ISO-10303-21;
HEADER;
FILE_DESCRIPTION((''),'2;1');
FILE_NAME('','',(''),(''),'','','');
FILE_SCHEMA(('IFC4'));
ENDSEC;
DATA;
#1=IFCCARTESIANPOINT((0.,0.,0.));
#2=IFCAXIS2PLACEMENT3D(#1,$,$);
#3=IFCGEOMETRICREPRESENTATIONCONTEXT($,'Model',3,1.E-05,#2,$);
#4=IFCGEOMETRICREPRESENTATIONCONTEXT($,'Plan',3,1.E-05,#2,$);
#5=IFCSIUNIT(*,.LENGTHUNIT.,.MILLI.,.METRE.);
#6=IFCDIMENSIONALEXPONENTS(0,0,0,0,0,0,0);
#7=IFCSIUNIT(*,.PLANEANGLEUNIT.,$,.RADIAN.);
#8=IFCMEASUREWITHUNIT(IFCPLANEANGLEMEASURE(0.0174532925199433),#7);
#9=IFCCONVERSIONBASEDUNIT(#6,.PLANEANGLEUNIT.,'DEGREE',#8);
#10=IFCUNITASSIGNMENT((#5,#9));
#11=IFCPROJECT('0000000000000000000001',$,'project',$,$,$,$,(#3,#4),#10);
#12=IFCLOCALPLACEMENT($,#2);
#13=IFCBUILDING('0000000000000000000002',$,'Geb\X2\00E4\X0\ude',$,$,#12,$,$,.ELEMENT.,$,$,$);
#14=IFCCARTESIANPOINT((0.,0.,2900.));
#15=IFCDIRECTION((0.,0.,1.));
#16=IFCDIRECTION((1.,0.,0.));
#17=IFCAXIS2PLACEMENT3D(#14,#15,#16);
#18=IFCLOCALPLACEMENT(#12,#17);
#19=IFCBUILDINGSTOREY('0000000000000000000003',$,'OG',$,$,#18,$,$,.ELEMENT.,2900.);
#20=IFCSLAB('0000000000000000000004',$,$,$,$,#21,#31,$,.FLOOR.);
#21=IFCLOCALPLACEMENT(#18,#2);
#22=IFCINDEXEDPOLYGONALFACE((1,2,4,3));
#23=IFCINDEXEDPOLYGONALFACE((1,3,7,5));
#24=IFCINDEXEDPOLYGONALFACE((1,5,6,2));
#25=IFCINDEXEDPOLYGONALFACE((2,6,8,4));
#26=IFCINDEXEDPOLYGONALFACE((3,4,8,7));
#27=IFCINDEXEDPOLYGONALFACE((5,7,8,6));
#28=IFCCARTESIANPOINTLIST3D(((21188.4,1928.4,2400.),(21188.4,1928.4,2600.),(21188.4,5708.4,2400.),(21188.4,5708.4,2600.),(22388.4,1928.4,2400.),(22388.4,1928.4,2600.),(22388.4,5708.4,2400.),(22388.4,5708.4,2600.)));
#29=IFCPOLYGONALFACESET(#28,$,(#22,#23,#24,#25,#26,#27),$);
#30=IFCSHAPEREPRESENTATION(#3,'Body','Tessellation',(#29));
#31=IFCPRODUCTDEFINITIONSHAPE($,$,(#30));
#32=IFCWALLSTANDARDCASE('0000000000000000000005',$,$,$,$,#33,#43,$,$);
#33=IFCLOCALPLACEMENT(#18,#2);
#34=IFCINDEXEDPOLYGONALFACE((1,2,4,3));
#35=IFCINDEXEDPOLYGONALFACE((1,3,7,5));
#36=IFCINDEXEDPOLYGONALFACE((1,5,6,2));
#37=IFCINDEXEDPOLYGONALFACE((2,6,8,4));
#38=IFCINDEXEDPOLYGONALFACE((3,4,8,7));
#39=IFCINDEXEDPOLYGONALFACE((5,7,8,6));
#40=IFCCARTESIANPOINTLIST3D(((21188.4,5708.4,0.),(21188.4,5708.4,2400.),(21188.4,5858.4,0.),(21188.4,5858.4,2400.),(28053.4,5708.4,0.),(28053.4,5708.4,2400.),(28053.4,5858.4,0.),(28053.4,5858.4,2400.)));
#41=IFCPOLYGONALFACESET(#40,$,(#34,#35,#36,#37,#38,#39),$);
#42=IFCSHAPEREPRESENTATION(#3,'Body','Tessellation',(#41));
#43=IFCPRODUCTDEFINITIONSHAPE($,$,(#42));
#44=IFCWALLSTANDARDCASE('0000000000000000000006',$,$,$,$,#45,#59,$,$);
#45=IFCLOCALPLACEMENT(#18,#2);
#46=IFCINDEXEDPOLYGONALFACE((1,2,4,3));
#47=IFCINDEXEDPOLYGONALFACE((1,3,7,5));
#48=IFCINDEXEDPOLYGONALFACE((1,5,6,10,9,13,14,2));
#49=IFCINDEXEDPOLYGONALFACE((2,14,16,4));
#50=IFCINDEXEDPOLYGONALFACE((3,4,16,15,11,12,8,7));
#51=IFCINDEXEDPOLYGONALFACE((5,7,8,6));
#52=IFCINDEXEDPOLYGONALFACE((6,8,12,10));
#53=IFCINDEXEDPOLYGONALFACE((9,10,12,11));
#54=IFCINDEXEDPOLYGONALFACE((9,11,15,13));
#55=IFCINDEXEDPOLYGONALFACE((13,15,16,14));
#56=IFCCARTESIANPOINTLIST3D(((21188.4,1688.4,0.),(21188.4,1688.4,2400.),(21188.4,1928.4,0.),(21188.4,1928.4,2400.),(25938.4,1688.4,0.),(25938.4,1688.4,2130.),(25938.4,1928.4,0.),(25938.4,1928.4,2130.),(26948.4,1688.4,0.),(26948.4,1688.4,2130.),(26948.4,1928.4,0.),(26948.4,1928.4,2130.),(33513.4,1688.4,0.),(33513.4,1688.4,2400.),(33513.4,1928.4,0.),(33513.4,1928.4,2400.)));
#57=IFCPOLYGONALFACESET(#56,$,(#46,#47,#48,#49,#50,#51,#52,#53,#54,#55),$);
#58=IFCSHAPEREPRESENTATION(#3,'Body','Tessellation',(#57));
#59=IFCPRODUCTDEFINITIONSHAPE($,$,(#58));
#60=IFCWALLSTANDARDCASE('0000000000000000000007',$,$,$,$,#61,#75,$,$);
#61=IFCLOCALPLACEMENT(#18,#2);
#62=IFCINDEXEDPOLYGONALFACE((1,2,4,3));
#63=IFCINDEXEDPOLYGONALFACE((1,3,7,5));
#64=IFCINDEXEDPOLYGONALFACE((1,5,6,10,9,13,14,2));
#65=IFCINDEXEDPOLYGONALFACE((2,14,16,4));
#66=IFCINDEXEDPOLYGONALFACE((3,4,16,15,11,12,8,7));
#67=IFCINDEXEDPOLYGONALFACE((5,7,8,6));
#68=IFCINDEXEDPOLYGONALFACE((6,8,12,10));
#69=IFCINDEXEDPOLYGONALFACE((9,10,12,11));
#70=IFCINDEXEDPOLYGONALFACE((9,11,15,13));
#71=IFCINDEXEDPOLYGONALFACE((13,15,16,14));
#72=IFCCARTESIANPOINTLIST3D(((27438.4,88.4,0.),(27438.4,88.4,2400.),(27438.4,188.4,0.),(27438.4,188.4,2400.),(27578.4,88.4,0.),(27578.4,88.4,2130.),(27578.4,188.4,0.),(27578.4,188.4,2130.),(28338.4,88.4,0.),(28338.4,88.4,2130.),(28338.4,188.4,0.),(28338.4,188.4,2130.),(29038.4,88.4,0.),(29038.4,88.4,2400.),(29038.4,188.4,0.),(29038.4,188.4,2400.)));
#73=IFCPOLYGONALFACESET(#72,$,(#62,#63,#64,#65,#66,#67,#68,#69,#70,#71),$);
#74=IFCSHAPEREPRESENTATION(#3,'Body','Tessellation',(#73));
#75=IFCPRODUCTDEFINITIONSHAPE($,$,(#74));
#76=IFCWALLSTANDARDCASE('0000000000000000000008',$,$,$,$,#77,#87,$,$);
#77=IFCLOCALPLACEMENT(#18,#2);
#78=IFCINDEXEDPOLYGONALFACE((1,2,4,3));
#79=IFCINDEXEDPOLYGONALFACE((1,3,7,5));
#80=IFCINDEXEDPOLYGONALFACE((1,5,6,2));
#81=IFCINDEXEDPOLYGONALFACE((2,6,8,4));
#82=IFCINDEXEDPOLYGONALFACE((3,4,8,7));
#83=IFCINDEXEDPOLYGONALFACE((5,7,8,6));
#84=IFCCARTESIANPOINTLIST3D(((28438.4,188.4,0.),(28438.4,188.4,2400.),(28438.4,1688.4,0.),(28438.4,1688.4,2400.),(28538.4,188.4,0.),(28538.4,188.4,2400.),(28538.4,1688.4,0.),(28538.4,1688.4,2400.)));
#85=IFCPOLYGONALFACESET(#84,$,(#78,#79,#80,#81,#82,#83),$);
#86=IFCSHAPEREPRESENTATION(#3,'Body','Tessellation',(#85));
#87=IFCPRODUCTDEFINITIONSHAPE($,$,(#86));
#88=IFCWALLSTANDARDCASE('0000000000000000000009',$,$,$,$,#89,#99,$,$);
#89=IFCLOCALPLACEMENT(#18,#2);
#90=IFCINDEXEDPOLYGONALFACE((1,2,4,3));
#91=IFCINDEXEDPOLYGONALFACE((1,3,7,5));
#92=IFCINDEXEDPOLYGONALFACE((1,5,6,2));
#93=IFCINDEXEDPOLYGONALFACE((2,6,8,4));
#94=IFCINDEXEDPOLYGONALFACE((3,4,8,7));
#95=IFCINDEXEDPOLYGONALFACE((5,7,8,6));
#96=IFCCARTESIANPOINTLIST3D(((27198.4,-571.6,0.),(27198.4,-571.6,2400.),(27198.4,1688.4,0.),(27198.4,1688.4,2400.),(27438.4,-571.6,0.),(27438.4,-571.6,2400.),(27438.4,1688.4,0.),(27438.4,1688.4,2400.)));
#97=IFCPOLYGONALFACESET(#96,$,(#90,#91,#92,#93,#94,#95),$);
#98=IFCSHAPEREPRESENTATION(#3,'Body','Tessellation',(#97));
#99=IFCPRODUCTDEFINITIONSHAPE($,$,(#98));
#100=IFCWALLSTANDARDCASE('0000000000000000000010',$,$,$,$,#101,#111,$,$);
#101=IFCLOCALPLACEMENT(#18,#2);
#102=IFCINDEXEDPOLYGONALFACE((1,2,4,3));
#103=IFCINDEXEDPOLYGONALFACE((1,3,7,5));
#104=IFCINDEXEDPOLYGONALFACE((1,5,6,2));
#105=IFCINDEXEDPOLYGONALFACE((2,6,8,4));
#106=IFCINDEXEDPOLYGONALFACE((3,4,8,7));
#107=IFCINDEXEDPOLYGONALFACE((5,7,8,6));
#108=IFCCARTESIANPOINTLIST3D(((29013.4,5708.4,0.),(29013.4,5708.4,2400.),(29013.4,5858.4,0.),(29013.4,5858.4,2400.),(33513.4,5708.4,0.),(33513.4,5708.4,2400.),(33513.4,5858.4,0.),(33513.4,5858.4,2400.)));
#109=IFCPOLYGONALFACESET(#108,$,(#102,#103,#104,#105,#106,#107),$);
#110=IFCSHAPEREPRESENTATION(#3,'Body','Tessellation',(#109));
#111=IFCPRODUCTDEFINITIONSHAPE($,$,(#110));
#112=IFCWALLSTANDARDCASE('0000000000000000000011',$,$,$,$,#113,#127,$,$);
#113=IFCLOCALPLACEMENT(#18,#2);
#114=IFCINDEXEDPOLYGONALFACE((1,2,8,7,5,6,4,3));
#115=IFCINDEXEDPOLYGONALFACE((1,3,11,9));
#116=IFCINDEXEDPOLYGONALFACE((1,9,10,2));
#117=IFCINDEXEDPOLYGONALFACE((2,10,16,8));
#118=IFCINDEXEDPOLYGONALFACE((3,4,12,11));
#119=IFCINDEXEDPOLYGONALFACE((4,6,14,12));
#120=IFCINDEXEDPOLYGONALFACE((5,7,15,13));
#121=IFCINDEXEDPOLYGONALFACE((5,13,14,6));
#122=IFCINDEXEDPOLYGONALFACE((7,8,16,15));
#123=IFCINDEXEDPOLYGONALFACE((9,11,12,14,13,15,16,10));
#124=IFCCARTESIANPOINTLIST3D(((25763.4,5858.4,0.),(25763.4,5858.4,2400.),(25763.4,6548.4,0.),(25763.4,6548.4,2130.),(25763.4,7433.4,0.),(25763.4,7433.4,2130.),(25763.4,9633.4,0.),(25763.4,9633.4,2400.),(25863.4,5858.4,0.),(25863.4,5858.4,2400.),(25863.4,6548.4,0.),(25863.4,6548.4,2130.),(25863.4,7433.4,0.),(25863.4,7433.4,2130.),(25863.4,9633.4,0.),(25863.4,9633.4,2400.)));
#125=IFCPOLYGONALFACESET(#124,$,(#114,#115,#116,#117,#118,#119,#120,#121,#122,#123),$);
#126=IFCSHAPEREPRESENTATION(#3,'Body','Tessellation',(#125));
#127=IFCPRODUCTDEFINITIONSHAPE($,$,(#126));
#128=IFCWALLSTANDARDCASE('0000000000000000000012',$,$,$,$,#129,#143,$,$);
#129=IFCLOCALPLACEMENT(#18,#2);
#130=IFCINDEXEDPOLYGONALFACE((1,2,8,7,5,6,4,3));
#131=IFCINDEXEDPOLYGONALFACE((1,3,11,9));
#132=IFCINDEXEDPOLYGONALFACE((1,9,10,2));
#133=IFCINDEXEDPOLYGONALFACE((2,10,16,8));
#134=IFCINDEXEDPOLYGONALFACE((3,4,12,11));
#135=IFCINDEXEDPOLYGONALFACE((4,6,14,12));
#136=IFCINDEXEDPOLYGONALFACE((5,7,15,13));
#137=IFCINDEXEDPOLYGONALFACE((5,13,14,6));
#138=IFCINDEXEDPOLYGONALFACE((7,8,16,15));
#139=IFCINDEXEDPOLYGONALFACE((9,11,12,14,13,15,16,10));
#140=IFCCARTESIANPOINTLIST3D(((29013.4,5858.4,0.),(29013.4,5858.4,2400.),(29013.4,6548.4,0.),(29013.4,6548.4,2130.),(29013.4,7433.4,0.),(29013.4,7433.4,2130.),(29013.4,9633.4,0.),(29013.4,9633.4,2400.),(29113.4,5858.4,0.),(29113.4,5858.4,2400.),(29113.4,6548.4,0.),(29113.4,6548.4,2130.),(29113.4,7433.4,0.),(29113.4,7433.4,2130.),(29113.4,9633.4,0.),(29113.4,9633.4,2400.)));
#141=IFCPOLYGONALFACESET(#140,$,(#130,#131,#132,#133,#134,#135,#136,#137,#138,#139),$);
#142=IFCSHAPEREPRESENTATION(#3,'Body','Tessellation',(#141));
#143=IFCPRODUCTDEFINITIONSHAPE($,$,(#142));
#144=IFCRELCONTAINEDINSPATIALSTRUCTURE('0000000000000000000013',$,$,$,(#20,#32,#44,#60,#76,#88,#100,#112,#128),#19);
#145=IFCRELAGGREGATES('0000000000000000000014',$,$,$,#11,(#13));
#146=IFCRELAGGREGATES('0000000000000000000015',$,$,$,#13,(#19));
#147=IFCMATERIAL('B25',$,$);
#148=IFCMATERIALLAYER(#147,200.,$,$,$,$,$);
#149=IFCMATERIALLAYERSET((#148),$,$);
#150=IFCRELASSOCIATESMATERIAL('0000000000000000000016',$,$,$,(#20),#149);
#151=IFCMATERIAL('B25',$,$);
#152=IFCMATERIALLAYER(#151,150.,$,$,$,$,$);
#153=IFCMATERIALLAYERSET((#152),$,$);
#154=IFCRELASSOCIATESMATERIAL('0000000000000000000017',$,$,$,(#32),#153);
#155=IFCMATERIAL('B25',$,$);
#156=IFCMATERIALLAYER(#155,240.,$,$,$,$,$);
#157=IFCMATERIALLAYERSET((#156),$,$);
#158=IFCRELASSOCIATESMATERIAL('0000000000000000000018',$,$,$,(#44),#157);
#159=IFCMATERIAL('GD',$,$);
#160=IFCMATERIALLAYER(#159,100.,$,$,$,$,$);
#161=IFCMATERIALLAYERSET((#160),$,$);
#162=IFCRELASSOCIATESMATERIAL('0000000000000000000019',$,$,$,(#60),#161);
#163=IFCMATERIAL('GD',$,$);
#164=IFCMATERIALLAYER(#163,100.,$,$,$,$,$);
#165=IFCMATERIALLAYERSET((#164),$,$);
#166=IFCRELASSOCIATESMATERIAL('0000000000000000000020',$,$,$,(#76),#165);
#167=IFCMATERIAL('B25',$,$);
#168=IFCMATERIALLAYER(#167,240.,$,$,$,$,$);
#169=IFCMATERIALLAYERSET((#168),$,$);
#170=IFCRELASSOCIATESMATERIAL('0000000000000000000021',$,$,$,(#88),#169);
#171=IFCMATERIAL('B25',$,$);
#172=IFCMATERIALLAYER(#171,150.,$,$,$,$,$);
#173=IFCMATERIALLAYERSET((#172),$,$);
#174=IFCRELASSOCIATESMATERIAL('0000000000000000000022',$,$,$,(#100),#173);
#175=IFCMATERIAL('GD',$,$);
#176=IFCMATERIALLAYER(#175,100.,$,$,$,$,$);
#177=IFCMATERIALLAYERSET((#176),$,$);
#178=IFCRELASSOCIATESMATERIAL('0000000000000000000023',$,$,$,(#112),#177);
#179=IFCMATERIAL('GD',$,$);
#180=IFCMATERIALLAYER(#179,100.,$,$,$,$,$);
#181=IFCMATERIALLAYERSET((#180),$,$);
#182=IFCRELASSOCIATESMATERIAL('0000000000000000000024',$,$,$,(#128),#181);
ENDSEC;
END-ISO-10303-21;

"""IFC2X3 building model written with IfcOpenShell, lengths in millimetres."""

from ifc_helpers import new_model, entity, si_unit, converted_unit, frame, frame_2d, origin, origin_with_axes, place, context, project, spatial, rectangle, extrude, material, layer, layer_set, layer_usage, element, save


model = new_model("IFC2X3")

# Units and contexts
model_context = context("Model", 3, precision=1e-05, world=origin())
plan_context = context("Plan", 3, precision=1e-05, world=origin())
ifc_project = project(units=[si_unit("LENGTHUNIT", "METRE", prefix="MILLI"), converted_unit("PLANEANGLEUNIT", "DEGREE", entity("IfcPlaneAngleMeasure", 0.0174532925199433), si_unit("PLANEANGLEUNIT", "RADIAN"), dimensions=[0, 0, 0, 0, 0, 0, 0])], contexts=[model_context, plan_context])

# Building, storey
building_placement = place(None, origin())
building = spatial("IfcBuilding", under=ifc_project, at=building_placement, Name="Gebäude", CompositionType="ELEMENT")
storey_placement = place(building_placement, frame((0.0, 0.0, 2900.0), z_axis=(0.0, 0.0, 1.0), x_axis=(1.0, 0.0, 0.0)))
storey = spatial("IfcBuildingStorey", under=building, at=storey_placement, Name="OG", CompositionType="ELEMENT", Elevation=2900.0)

# Slab
ifc_material_1 = material(Name="B25")
ifc_layer_1 = layer(ifc_material_1, 200.0)
ifc_layer_set_1 = layer_set([ifc_layer_1])
ifc_layer_usage_1 = layer_usage(ifc_layer_set_1, "AXIS3", "POSITIVE", 0.0)
slab_placement = place(storey_placement, frame((21188.4, 5708.4, 2400.0), z_axis=(0.0, 0.0, 1.0), x_axis=(1.0, 0.0, 0.0)))
element("IfcSlab", 1, at=slab_placement, inside=storey, material=ifc_layer_usage_1, PredefinedType="FLOOR", context=model_context, shape_type="SweptSolid", body=[
    extrude(rectangle(XDim=3780.0, YDim=1200.0, at=frame_2d((600.0, -1890.0), x_axis=(0.0, -1.0))), origin_with_axes(), (0.0, 0.0, 1.0), 200.0),
])

# Wall
ifc_material_2 = material(Name="B25")
ifc_layer_2 = layer(ifc_material_2, 150.0)
ifc_layer_set_2 = layer_set([ifc_layer_2])
ifc_layer_usage_2 = layer_usage(ifc_layer_set_2, "AXIS2", "POSITIVE", 0.0)
wall_1_placement = place(storey_placement, frame((21188.4, 5708.4, 0.0), z_axis=(0.0, 0.0, 1.0), x_axis=(1.0, 0.0, 0.0)))
element("IfcWallStandardCase", 2, at=wall_1_placement, inside=storey, material=ifc_layer_usage_2, context=model_context, shape_type="SweptSolid", body=[
    extrude(rectangle(XDim=6865.0, YDim=150.0, at=frame_2d((3432.5, 75.0), x_axis=(1.0, 0.0))), origin_with_axes(), (0.0, 0.0, 1.0), 2400.0),
])

# Walls, openings
ifc_material_3 = material(Name="B25")
ifc_layer_3 = layer(ifc_material_3, 240.0)
ifc_layer_set_3 = layer_set([ifc_layer_3])
ifc_layer_usage_3 = layer_usage(ifc_layer_set_3, "AXIS2", "POSITIVE", 0.0)
wall_2_placement = place(storey_placement, frame((33513.4, 1928.4, 0.0), z_axis=(0.0, 0.0, 1.0), x_axis=(-1.0, 0.0, 0.0)))
wall_2 = element("IfcWallStandardCase", 3, at=wall_2_placement, inside=storey, material=ifc_layer_usage_3, context=model_context, shape_type="SweptSolid", body=[
    extrude(rectangle(XDim=12325.0, YDim=240.0, at=frame_2d((6162.5, 120.0), x_axis=(1.0, 0.0))), origin_with_axes(), (0.0, 0.0, 1.0), 2400.0),
])
opening_1_placement = place(wall_2_placement, frame((6565.0, 0.0, 0.0), z_axis=(0.0, 1.0, 0.0), x_axis=(0.0, 0.0, 1.0)))
element("IfcOpeningElement", 4, at=opening_1_placement, cuts=wall_2, ObjectType="Opening", context=model_context, shape_type="SweptSolid", body=[
    extrude(rectangle(XDim=2130.0, YDim=1010.0, at=frame_2d((1065.0, 505.0), x_axis=(1.0, 0.0))), origin_with_axes(), (0.0, 0.0, 1.0), 240.0),
])
ifc_material_4 = material(Name="GD")
ifc_layer_4 = layer(ifc_material_4, 100.0)
ifc_layer_set_4 = layer_set([ifc_layer_4])
ifc_layer_usage_4 = layer_usage(ifc_layer_set_4, "AXIS2", "POSITIVE", 0.0)
wall_3_placement = place(storey_placement, frame((29038.4, 188.4, 0.0), z_axis=(0.0, 0.0, 1.0), x_axis=(-1.0, 0.0, 0.0)))
wall_3 = element("IfcWallStandardCase", 5, at=wall_3_placement, inside=storey, material=ifc_layer_usage_4, context=model_context, shape_type="SweptSolid", body=[
    extrude(rectangle(XDim=1600.0, YDim=100.0, at=frame_2d((800.0, 50.0), x_axis=(1.0, 0.0))), origin_with_axes(), (0.0, 0.0, 1.0), 2400.0),
])
opening_2_placement = place(wall_3_placement, frame((700.0, 0.0, 0.0), z_axis=(0.0, 1.0, 0.0), x_axis=(0.0, 0.0, 1.0)))
element("IfcOpeningElement", 6, at=opening_2_placement, cuts=wall_3, ObjectType="Opening", context=model_context, shape_type="SweptSolid", body=[
    extrude(rectangle(XDim=2130.0, YDim=760.0, at=frame_2d((1065.0, 380.0), x_axis=(1.0, 0.0))), origin_with_axes(), (0.0, 0.0, 1.0), 100.0),
])

# Walls
ifc_material_5 = material(Name="GD")
ifc_layer_5 = layer(ifc_material_5, 100.0)
ifc_layer_set_5 = layer_set([ifc_layer_5])
ifc_layer_usage_5 = layer_usage(ifc_layer_set_5, "AXIS2", "POSITIVE", 0.0)
wall_4_placement = place(storey_placement, frame((28438.4, 1688.4, 0.0), z_axis=(0.0, 0.0, 1.0), x_axis=(0.0, -1.0, 0.0)))
element("IfcWallStandardCase", 7, at=wall_4_placement, inside=storey, material=ifc_layer_usage_5, context=model_context, shape_type="SweptSolid", body=[
    extrude(rectangle(XDim=1500.0, YDim=100.0, at=frame_2d((750.0, 50.0), x_axis=(1.0, 0.0))), origin_with_axes(), (0.0, 0.0, 1.0), 2400.0),
])
ifc_material_6 = material(Name="B25")
ifc_layer_6 = layer(ifc_material_6, 240.0)
ifc_layer_set_6 = layer_set([ifc_layer_6])
ifc_layer_usage_6 = layer_usage(ifc_layer_set_6, "AXIS2", "POSITIVE", 0.0)
wall_5_placement = place(storey_placement, frame((27198.4, 1688.4, 0.0), z_axis=(0.0, 0.0, 1.0), x_axis=(0.0, -1.0, 0.0)))
element("IfcWallStandardCase", 8, at=wall_5_placement, inside=storey, material=ifc_layer_usage_6, context=model_context, shape_type="SweptSolid", body=[
    extrude(rectangle(XDim=2260.0, YDim=240.0, at=frame_2d((1130.0, 120.0), x_axis=(1.0, 0.0))), origin_with_axes(), (0.0, 0.0, 1.0), 2400.0),
])
ifc_material_7 = material(Name="B25")
ifc_layer_7 = layer(ifc_material_7, 150.0)
ifc_layer_set_7 = layer_set([ifc_layer_7])
ifc_layer_usage_7 = layer_usage(ifc_layer_set_7, "AXIS2", "POSITIVE", 0.0)
wall_6_placement = place(storey_placement, frame((29013.4, 5708.4, 0.0), z_axis=(0.0, 0.0, 1.0), x_axis=(1.0, 0.0, 0.0)))
element("IfcWallStandardCase", 9, at=wall_6_placement, inside=storey, material=ifc_layer_usage_7, context=model_context, shape_type="SweptSolid", body=[
    extrude(rectangle(XDim=4500.0, YDim=150.0, at=frame_2d((2250.0, 75.0), x_axis=(1.0, 0.0))), origin_with_axes(), (0.0, 0.0, 1.0), 2400.0),
])

# Walls, openings
ifc_material_8 = material(Name="GD")
ifc_layer_8 = layer(ifc_material_8, 100.0)
ifc_layer_set_8 = layer_set([ifc_layer_8])
ifc_layer_usage_8 = layer_usage(ifc_layer_set_8, "AXIS2", "POSITIVE", 0.0)
wall_7_placement = place(storey_placement, frame((25763.4, 9633.4, 0.0), z_axis=(0.0, 0.0, 1.0), x_axis=(0.0, -1.0, 0.0)))
wall_7 = element("IfcWallStandardCase", 10, at=wall_7_placement, inside=storey, material=ifc_layer_usage_8, context=model_context, shape_type="SweptSolid", body=[
    extrude(rectangle(XDim=3775.0, YDim=100.0, at=frame_2d((1887.5, 50.0), x_axis=(1.0, 0.0))), origin_with_axes(), (0.0, 0.0, 1.0), 2400.0),
])
opening_3_placement = place(wall_7_placement, frame((2200.0, 0.0, 0.0), z_axis=(0.0, 1.0, 0.0), x_axis=(0.0, 0.0, 1.0)))
element("IfcOpeningElement", 11, at=opening_3_placement, cuts=wall_7, ObjectType="Opening", context=model_context, shape_type="SweptSolid", body=[
    extrude(rectangle(XDim=2130.0, YDim=885.0, at=frame_2d((1065.0, 442.5), x_axis=(1.0, 0.0))), origin_with_axes(), (0.0, 0.0, 1.0), 100.0),
])
ifc_material_9 = material(Name="GD")
ifc_layer_9 = layer(ifc_material_9, 100.0)
ifc_layer_set_9 = layer_set([ifc_layer_9])
ifc_layer_usage_9 = layer_usage(ifc_layer_set_9, "AXIS2", "POSITIVE", 0.0)
wall_8_placement = place(storey_placement, frame((29113.4, 5858.4, 0.0), z_axis=(0.0, 0.0, 1.0), x_axis=(0.0, 1.0, 0.0)))
wall_8 = element("IfcWallStandardCase", 12, at=wall_8_placement, inside=storey, material=ifc_layer_usage_9, context=model_context, shape_type="SweptSolid", body=[
    extrude(rectangle(XDim=3775.0, YDim=100.0, at=frame_2d((1887.5, 50.0), x_axis=(1.0, 0.0))), origin_with_axes(), (0.0, 0.0, 1.0), 2400.0),
])
opening_4_placement = place(wall_8_placement, frame((690.0, 0.0, 0.0), z_axis=(0.0, 1.0, 0.0), x_axis=(0.0, 0.0, 1.0)))
element("IfcOpeningElement", 13, at=opening_4_placement, cuts=wall_8, ObjectType="Opening", context=model_context, shape_type="SweptSolid", body=[
    extrude(rectangle(XDim=2130.0, YDim=885.0, at=frame_2d((1065.0, 442.5), x_axis=(1.0, 0.0))), origin_with_axes(), (0.0, 0.0, 1.0), 100.0),
])

save(model, "model.ifc")
